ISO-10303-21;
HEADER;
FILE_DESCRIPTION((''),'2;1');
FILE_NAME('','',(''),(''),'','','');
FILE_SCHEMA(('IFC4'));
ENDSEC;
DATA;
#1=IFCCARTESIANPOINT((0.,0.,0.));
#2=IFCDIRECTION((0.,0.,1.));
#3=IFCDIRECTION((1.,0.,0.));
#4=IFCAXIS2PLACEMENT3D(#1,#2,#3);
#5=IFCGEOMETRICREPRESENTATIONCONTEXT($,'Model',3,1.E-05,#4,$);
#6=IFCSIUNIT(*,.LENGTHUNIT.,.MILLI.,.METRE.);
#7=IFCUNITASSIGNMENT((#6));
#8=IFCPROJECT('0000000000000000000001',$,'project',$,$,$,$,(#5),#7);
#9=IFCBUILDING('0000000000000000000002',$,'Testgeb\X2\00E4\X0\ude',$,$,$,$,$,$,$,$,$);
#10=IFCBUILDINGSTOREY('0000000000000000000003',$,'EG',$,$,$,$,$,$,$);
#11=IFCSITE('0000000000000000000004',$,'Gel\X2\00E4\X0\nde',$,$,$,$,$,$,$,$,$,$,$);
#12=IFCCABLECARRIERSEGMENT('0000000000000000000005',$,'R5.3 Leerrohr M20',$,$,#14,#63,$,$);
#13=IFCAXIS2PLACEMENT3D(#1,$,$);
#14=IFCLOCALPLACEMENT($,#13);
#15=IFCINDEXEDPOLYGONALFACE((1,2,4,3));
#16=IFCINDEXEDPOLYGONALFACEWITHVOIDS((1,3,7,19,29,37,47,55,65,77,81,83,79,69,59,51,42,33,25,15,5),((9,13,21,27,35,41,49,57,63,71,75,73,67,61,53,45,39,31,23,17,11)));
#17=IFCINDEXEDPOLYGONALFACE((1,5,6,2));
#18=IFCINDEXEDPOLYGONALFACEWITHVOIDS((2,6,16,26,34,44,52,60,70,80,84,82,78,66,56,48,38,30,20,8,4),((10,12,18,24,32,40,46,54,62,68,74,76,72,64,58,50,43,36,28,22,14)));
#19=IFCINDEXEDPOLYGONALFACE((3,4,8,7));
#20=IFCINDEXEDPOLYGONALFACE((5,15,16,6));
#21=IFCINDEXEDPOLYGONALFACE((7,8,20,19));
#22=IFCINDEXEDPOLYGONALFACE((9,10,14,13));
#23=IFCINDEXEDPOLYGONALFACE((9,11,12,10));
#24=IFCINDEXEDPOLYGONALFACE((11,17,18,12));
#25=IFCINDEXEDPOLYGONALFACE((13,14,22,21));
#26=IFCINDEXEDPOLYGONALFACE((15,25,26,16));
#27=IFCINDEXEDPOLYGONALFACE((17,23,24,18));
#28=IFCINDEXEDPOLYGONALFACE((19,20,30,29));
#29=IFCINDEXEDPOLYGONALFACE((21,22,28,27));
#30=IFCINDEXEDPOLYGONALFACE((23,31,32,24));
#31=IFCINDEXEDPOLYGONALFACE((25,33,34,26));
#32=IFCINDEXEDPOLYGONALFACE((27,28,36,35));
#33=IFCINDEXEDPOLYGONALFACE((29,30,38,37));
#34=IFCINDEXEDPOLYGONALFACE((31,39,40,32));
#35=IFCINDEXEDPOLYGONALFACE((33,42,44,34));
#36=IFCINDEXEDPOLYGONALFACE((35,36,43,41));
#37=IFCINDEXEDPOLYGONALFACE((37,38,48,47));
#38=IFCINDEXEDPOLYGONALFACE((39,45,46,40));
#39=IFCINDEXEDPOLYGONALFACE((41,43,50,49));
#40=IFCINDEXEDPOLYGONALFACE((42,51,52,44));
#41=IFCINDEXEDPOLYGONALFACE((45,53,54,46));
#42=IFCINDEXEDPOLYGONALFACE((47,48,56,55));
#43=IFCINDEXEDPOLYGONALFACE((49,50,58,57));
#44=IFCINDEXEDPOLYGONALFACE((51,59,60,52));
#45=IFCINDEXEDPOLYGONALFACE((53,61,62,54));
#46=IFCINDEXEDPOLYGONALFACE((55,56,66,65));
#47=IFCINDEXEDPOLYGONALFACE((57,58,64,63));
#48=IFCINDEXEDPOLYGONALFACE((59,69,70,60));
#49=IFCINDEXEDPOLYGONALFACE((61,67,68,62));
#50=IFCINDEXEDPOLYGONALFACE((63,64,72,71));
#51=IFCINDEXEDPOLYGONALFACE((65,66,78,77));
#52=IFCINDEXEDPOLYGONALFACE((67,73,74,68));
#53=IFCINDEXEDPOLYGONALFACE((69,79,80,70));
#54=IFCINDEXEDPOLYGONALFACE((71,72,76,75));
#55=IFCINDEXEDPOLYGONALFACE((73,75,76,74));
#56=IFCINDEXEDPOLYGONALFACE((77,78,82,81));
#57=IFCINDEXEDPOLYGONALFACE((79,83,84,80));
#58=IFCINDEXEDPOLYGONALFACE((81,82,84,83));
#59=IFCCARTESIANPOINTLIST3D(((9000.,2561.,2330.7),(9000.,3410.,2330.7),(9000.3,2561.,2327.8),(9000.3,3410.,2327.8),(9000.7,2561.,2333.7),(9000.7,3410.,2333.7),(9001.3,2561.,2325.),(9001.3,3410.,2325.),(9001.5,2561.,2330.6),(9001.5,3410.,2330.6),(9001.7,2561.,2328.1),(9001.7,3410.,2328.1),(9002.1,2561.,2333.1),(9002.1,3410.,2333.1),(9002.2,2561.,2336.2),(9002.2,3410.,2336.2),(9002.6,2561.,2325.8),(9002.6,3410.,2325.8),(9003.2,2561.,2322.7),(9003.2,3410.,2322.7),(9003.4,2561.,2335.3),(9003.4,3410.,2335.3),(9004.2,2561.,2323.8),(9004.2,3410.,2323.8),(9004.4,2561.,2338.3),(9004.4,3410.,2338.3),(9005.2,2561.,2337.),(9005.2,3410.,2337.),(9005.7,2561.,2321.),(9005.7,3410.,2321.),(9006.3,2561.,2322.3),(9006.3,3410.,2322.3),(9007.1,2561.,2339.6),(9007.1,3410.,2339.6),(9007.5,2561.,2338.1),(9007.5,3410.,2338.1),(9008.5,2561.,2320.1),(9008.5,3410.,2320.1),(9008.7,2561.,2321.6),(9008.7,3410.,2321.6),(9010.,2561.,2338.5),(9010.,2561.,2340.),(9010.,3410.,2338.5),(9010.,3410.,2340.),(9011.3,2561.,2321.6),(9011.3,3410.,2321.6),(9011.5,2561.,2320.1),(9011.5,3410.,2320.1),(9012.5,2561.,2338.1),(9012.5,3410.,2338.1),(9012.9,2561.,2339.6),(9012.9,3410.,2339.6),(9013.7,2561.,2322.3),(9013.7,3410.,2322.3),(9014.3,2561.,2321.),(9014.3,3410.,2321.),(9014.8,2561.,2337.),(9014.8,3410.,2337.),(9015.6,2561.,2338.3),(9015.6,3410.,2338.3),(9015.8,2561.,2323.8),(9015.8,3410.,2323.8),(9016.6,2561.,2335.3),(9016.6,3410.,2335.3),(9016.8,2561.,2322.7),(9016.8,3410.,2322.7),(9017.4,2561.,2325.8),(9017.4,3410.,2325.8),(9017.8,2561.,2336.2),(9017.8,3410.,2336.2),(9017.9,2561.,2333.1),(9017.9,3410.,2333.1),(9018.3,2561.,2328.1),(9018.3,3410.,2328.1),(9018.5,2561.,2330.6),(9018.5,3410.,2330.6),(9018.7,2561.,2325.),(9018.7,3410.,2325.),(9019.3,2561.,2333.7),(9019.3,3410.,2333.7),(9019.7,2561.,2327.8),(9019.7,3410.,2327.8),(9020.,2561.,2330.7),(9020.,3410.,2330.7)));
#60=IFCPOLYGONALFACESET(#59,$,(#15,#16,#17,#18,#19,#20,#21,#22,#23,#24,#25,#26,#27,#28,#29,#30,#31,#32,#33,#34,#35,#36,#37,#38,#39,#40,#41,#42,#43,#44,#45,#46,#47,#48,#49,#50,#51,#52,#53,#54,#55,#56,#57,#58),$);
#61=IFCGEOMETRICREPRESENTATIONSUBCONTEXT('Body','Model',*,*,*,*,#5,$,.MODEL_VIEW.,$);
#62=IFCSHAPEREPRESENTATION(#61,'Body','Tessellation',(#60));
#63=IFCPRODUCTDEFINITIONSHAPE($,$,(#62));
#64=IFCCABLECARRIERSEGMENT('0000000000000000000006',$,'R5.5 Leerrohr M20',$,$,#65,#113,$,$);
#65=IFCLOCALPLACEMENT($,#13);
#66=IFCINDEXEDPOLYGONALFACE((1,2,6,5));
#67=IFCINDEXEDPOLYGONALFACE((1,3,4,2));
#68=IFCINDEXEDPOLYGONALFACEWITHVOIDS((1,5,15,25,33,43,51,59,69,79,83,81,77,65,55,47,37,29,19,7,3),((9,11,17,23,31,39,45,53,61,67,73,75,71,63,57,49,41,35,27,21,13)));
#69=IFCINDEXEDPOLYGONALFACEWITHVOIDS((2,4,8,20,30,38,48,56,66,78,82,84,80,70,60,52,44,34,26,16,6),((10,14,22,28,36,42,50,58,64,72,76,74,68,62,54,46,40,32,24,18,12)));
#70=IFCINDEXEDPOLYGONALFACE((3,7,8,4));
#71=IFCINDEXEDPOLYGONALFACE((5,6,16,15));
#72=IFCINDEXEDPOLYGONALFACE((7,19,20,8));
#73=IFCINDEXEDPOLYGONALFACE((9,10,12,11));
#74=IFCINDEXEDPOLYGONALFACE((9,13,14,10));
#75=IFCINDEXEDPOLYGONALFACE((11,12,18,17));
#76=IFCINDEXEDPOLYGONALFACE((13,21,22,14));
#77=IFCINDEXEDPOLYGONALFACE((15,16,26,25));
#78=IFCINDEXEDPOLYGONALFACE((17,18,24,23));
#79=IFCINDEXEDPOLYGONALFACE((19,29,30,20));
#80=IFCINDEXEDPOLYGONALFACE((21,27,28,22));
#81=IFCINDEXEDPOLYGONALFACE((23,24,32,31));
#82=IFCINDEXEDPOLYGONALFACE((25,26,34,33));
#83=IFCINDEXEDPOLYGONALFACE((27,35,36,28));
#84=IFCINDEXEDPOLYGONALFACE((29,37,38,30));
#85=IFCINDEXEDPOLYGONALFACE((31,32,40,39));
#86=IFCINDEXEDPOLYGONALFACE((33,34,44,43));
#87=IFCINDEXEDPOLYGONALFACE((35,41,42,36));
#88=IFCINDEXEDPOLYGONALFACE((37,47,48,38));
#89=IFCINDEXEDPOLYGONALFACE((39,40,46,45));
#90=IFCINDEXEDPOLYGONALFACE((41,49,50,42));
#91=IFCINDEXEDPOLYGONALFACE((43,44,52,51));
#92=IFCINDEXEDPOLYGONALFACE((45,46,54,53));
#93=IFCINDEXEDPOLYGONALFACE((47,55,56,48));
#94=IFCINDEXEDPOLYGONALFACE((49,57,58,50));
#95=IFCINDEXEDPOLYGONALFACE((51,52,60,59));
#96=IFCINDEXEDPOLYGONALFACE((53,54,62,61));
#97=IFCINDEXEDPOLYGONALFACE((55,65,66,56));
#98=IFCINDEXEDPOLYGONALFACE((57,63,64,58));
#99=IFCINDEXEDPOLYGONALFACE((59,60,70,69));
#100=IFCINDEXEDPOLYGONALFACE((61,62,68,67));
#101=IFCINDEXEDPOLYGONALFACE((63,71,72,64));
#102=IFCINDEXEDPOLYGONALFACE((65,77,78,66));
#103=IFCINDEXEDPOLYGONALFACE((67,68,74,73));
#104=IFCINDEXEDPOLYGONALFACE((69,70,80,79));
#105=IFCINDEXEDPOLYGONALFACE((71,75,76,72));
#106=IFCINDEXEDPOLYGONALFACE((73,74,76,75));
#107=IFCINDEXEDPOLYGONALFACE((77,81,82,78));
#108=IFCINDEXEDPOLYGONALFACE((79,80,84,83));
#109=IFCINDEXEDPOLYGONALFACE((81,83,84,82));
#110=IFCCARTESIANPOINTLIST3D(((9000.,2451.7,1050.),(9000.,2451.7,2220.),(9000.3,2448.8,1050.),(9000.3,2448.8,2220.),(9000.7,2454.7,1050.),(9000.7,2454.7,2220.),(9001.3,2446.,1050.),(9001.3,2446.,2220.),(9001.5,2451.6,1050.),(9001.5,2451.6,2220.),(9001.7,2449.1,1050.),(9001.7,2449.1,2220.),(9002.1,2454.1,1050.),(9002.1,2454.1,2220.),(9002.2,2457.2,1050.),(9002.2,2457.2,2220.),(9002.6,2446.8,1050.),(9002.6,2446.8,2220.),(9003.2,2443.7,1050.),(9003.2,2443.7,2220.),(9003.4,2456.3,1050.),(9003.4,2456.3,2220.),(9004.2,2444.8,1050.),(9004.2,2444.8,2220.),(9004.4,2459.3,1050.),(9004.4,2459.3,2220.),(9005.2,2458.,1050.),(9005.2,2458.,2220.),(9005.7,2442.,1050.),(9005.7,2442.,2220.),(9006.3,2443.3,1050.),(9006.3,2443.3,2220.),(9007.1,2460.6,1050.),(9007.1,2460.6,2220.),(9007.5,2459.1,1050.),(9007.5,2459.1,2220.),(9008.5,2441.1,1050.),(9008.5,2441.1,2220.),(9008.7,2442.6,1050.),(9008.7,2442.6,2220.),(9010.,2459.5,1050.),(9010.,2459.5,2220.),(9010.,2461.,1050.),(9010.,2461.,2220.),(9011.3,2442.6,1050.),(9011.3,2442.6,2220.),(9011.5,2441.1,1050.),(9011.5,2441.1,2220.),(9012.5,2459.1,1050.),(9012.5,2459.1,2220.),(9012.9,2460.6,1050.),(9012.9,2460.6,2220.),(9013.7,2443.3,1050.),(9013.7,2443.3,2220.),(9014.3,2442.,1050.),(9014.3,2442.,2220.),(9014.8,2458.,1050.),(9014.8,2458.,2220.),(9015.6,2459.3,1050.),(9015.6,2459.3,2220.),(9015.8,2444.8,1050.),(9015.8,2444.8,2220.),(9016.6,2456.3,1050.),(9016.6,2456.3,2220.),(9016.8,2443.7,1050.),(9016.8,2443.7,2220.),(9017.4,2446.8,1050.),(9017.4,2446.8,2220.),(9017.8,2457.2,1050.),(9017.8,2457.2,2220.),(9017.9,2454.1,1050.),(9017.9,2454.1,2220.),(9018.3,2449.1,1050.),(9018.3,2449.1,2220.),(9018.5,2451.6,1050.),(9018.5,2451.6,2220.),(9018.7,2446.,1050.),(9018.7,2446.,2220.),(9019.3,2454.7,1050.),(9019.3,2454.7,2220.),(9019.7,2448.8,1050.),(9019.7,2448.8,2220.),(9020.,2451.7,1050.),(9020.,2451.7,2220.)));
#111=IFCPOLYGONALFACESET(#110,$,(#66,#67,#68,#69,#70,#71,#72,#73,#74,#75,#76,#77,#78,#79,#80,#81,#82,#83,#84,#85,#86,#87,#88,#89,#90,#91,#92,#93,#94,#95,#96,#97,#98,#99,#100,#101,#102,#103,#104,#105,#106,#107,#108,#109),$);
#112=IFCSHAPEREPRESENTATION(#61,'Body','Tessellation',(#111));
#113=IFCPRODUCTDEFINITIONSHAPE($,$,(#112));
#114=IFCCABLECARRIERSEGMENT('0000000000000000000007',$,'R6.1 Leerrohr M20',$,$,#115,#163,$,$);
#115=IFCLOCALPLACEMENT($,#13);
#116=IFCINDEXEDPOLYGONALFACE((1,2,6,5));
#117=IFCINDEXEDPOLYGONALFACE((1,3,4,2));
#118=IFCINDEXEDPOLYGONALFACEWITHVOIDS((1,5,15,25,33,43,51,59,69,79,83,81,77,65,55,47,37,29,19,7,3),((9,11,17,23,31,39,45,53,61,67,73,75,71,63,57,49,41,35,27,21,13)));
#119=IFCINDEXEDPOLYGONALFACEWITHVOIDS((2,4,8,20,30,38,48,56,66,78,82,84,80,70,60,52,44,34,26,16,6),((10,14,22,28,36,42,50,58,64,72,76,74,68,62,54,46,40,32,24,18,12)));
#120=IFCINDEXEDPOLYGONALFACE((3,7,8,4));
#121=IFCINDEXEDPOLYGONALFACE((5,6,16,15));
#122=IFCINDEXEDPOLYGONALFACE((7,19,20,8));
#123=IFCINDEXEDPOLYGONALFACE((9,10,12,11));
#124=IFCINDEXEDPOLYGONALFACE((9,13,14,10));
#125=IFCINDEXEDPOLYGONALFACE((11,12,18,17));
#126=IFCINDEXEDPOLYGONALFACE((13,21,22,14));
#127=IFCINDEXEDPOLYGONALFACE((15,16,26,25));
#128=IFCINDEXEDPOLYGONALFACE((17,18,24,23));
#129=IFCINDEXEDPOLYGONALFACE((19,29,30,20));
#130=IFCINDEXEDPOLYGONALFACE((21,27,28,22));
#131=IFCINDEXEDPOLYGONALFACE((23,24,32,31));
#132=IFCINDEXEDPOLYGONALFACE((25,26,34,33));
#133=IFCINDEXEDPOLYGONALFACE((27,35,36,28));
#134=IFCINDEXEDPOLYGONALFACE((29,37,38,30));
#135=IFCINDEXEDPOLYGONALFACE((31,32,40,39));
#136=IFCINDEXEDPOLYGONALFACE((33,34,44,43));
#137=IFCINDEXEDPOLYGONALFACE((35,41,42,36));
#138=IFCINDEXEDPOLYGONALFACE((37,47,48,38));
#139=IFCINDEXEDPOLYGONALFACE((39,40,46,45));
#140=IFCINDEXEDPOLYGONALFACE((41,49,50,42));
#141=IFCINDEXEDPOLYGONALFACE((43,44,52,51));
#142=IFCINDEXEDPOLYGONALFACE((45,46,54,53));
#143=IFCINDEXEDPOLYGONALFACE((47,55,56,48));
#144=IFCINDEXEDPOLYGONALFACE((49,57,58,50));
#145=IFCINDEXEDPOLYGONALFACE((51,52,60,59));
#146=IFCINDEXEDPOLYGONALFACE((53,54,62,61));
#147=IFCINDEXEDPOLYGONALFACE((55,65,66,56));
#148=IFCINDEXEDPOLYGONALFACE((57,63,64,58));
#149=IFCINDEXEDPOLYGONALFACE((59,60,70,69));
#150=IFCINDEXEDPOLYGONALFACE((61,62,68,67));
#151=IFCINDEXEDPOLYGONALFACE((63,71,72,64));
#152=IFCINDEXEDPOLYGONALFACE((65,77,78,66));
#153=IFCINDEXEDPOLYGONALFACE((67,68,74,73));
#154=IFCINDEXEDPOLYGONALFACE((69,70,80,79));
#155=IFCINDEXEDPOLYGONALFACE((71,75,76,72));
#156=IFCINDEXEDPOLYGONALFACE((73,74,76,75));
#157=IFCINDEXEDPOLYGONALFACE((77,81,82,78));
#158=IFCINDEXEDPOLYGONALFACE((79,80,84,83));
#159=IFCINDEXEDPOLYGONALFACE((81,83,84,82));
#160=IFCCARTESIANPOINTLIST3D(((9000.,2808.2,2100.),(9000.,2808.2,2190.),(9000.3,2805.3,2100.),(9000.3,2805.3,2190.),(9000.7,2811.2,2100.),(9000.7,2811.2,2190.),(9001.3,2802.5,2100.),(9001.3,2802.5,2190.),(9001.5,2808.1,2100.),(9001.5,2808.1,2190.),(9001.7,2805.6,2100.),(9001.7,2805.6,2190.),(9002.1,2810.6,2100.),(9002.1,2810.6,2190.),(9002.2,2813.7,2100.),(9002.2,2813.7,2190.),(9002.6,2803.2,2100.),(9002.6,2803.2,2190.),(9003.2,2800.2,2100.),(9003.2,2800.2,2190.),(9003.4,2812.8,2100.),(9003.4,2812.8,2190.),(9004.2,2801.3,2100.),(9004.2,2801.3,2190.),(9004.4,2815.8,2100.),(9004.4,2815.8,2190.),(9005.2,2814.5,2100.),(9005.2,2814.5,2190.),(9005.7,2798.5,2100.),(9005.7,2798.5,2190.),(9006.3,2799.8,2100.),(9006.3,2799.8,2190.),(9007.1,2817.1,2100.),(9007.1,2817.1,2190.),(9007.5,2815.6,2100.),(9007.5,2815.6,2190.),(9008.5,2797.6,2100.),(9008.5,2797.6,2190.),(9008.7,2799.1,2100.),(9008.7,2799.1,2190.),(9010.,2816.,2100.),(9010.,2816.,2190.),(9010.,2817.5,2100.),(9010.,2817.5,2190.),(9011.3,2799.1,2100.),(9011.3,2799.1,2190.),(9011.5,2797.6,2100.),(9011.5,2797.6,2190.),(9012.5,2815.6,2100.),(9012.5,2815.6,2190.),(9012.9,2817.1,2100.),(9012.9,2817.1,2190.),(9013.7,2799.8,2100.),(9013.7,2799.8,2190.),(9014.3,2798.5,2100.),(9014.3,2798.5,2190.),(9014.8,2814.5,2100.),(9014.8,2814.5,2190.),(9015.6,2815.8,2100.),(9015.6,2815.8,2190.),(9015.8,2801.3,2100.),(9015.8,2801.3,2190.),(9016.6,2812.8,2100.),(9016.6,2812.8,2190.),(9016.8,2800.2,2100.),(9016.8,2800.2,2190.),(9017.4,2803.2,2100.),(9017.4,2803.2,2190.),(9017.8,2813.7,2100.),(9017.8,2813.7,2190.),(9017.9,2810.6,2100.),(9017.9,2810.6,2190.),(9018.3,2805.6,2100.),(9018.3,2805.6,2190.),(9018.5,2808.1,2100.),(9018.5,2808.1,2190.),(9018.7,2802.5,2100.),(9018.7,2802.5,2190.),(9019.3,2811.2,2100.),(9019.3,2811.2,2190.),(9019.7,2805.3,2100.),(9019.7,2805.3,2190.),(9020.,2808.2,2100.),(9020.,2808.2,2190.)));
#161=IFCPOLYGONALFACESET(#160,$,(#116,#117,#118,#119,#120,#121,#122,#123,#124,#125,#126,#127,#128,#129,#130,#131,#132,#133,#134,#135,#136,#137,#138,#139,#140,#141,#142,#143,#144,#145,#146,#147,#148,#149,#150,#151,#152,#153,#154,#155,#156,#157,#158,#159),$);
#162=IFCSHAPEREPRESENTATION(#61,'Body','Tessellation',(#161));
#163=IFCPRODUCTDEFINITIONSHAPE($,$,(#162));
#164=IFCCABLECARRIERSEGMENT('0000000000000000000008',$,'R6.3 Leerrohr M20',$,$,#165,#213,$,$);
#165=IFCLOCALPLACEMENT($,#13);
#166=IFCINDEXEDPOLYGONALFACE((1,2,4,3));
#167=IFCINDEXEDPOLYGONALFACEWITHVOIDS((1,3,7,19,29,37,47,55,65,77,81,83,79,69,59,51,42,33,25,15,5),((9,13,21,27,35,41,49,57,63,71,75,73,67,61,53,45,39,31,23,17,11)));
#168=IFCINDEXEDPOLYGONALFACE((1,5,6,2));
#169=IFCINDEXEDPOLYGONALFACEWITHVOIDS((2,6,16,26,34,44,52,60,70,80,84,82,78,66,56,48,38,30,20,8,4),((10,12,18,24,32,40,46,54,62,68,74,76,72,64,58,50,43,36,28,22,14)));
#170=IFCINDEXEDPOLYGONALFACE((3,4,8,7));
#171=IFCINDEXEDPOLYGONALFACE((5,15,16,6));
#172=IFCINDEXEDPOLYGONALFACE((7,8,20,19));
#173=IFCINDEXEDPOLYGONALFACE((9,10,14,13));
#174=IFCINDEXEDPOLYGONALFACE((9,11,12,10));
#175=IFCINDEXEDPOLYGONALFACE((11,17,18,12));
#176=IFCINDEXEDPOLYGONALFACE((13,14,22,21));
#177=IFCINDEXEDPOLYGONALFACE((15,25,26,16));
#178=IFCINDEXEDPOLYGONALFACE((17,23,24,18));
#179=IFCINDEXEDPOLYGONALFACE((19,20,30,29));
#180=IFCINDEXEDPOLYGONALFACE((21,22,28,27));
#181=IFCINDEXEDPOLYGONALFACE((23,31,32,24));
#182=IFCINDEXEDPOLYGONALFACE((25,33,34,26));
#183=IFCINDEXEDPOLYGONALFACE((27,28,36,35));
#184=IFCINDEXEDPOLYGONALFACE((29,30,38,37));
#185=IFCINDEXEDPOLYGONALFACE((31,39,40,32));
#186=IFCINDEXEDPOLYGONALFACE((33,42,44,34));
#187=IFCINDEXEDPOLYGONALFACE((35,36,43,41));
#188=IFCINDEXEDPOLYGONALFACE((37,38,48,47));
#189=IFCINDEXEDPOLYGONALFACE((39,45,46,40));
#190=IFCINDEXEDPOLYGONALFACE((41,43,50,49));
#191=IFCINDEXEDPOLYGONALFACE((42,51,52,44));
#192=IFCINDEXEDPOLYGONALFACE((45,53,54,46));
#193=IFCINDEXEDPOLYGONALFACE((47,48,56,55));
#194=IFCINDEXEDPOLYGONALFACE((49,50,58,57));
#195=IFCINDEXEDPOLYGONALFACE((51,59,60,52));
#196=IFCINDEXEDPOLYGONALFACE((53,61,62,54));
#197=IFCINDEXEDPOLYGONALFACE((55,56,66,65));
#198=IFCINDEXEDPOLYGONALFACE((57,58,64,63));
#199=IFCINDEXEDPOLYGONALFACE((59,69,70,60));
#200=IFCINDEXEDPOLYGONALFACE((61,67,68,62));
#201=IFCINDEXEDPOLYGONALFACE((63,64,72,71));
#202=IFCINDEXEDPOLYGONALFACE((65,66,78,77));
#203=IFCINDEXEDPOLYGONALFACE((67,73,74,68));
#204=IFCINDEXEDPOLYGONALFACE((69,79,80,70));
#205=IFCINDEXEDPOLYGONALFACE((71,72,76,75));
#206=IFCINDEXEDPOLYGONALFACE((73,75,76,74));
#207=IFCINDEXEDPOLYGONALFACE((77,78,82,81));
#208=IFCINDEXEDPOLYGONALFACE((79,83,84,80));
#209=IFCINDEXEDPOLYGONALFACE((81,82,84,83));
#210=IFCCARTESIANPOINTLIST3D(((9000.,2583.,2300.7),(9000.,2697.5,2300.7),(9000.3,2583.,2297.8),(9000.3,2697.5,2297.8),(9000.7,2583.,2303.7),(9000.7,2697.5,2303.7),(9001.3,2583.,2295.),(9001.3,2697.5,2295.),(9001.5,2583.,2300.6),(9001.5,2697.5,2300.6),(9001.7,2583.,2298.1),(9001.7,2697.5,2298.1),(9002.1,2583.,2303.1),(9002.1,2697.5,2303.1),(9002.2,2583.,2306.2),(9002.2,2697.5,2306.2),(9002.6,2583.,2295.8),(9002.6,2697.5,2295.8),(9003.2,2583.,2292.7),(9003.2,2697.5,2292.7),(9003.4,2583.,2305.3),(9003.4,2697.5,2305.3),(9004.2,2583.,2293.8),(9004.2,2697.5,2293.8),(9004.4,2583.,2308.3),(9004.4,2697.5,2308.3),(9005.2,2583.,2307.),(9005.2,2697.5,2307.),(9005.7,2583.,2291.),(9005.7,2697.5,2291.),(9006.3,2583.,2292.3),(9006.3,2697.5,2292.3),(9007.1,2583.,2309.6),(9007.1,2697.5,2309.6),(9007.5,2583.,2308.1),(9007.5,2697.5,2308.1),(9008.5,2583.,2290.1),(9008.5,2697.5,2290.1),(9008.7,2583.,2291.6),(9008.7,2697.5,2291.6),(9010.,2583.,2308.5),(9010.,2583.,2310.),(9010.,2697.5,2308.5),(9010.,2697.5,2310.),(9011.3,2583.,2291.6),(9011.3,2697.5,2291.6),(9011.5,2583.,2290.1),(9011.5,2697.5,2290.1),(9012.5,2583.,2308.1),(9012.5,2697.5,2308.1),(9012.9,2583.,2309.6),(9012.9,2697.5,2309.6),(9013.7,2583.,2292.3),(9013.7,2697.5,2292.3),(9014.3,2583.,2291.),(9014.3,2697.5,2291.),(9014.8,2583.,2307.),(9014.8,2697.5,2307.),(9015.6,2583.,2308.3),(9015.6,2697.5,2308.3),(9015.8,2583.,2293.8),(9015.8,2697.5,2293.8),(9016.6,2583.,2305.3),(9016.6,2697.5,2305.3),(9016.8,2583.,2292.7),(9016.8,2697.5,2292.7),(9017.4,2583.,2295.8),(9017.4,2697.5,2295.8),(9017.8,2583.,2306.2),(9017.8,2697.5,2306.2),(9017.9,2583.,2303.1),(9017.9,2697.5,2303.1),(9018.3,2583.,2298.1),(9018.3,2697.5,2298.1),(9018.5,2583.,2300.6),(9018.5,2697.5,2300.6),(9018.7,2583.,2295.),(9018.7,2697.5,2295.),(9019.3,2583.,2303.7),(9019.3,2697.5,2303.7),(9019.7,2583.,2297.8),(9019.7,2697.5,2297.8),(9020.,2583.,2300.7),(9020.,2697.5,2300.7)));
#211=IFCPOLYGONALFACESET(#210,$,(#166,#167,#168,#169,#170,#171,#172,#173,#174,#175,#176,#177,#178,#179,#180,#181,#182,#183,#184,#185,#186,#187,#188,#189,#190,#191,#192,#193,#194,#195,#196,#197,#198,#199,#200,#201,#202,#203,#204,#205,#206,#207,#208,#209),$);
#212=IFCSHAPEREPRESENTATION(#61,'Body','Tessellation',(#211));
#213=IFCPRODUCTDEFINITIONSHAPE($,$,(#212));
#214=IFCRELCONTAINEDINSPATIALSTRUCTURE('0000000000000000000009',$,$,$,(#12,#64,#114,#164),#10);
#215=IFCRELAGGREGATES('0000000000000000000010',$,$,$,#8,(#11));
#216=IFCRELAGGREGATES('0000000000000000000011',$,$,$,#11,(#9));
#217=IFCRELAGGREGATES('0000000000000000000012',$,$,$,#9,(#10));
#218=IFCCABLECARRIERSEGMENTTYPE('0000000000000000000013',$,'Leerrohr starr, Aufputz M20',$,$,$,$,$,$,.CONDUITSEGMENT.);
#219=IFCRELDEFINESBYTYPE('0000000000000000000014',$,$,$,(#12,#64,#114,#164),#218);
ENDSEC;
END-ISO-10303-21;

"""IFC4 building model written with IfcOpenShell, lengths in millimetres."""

from ifc_helpers import new_model, si_unit, frame, origin_with_axes, place, context, subcontext, project, spatial, hollow_circle, extrude, type_object, element, save


model = new_model("IFC4")

# Units and contexts
model_context = context("Model", 3, precision=1e-05, world=origin_with_axes())
body_context = subcontext(model_context, "Body", "Model", "MODEL_VIEW")
ifc_project = project(units=[si_unit("LENGTHUNIT", "METRE", prefix="MILLI")], contexts=[model_context])

# Site, building, storey
site = spatial("IfcSite", under=ifc_project, Name="Gelände")
building = spatial("IfcBuilding", under=site, Name="Testgebäude")
storey = spatial("IfcBuildingStorey", under=building, Name="EG")

# Cable carrier segments
cable_carrier_segment_type_1 = type_object("IfcCableCarrierSegmentType", Name="Leerrohr starr, Aufputz M20", PredefinedType="CONDUITSEGMENT")
cable_carrier_segment_1_placement = place(None, frame((9010.0, 3410.0, 2330.0), z_axis=(0.0, -1.0, 0.0), x_axis=(0.0, 0.0, 1.0)))
element("IfcCableCarrierSegment", 1, at=cable_carrier_segment_1_placement, inside=storey, type_object=cable_carrier_segment_type_1, Name="R5.3 Leerrohr M20", context=body_context, shape_type="SweptSolid", body=[
    extrude(hollow_circle(Radius=10.0, WallThickness=1.5), None, (0.0, 0.0, 1.0), 849.0),
])
cable_carrier_segment_2_placement = place(None, frame((9010.0, 2451.0, 2220.0), z_axis=(0.0, 0.0, -1.0), x_axis=(0.0, 1.0, 0.0)))
element("IfcCableCarrierSegment", 2, at=cable_carrier_segment_2_placement, inside=storey, type_object=cable_carrier_segment_type_1, Name="R5.5 Leerrohr M20", context=body_context, shape_type="SweptSolid", body=[
    extrude(hollow_circle(Radius=10.0, WallThickness=1.5), None, (0.0, 0.0, 1.0), 1170.0),
])
cable_carrier_segment_3_placement = place(None, frame((9010.0, 2807.5, 2100.0), z_axis=(0.0, 0.0, 1.0), x_axis=(0.0, 1.0, 0.0)))
element("IfcCableCarrierSegment", 3, at=cable_carrier_segment_3_placement, inside=storey, type_object=cable_carrier_segment_type_1, Name="R6.1 Leerrohr M20", context=body_context, shape_type="SweptSolid", body=[
    extrude(hollow_circle(Radius=10.0, WallThickness=1.5), None, (0.0, 0.0, 1.0), 90.0),
])
cable_carrier_segment_4_placement = place(None, frame((9010.0, 2697.5, 2300.0), z_axis=(0.0, -1.0, 0.0), x_axis=(0.0, 0.0, 1.0)))
element("IfcCableCarrierSegment", 4, at=cable_carrier_segment_4_placement, inside=storey, type_object=cable_carrier_segment_type_1, Name="R6.3 Leerrohr M20", context=body_context, shape_type="SweptSolid", body=[
    extrude(hollow_circle(Radius=10.0, WallThickness=1.5), None, (0.0, 0.0, 1.0), 114.5),
])

save(model, "model.ifc")
